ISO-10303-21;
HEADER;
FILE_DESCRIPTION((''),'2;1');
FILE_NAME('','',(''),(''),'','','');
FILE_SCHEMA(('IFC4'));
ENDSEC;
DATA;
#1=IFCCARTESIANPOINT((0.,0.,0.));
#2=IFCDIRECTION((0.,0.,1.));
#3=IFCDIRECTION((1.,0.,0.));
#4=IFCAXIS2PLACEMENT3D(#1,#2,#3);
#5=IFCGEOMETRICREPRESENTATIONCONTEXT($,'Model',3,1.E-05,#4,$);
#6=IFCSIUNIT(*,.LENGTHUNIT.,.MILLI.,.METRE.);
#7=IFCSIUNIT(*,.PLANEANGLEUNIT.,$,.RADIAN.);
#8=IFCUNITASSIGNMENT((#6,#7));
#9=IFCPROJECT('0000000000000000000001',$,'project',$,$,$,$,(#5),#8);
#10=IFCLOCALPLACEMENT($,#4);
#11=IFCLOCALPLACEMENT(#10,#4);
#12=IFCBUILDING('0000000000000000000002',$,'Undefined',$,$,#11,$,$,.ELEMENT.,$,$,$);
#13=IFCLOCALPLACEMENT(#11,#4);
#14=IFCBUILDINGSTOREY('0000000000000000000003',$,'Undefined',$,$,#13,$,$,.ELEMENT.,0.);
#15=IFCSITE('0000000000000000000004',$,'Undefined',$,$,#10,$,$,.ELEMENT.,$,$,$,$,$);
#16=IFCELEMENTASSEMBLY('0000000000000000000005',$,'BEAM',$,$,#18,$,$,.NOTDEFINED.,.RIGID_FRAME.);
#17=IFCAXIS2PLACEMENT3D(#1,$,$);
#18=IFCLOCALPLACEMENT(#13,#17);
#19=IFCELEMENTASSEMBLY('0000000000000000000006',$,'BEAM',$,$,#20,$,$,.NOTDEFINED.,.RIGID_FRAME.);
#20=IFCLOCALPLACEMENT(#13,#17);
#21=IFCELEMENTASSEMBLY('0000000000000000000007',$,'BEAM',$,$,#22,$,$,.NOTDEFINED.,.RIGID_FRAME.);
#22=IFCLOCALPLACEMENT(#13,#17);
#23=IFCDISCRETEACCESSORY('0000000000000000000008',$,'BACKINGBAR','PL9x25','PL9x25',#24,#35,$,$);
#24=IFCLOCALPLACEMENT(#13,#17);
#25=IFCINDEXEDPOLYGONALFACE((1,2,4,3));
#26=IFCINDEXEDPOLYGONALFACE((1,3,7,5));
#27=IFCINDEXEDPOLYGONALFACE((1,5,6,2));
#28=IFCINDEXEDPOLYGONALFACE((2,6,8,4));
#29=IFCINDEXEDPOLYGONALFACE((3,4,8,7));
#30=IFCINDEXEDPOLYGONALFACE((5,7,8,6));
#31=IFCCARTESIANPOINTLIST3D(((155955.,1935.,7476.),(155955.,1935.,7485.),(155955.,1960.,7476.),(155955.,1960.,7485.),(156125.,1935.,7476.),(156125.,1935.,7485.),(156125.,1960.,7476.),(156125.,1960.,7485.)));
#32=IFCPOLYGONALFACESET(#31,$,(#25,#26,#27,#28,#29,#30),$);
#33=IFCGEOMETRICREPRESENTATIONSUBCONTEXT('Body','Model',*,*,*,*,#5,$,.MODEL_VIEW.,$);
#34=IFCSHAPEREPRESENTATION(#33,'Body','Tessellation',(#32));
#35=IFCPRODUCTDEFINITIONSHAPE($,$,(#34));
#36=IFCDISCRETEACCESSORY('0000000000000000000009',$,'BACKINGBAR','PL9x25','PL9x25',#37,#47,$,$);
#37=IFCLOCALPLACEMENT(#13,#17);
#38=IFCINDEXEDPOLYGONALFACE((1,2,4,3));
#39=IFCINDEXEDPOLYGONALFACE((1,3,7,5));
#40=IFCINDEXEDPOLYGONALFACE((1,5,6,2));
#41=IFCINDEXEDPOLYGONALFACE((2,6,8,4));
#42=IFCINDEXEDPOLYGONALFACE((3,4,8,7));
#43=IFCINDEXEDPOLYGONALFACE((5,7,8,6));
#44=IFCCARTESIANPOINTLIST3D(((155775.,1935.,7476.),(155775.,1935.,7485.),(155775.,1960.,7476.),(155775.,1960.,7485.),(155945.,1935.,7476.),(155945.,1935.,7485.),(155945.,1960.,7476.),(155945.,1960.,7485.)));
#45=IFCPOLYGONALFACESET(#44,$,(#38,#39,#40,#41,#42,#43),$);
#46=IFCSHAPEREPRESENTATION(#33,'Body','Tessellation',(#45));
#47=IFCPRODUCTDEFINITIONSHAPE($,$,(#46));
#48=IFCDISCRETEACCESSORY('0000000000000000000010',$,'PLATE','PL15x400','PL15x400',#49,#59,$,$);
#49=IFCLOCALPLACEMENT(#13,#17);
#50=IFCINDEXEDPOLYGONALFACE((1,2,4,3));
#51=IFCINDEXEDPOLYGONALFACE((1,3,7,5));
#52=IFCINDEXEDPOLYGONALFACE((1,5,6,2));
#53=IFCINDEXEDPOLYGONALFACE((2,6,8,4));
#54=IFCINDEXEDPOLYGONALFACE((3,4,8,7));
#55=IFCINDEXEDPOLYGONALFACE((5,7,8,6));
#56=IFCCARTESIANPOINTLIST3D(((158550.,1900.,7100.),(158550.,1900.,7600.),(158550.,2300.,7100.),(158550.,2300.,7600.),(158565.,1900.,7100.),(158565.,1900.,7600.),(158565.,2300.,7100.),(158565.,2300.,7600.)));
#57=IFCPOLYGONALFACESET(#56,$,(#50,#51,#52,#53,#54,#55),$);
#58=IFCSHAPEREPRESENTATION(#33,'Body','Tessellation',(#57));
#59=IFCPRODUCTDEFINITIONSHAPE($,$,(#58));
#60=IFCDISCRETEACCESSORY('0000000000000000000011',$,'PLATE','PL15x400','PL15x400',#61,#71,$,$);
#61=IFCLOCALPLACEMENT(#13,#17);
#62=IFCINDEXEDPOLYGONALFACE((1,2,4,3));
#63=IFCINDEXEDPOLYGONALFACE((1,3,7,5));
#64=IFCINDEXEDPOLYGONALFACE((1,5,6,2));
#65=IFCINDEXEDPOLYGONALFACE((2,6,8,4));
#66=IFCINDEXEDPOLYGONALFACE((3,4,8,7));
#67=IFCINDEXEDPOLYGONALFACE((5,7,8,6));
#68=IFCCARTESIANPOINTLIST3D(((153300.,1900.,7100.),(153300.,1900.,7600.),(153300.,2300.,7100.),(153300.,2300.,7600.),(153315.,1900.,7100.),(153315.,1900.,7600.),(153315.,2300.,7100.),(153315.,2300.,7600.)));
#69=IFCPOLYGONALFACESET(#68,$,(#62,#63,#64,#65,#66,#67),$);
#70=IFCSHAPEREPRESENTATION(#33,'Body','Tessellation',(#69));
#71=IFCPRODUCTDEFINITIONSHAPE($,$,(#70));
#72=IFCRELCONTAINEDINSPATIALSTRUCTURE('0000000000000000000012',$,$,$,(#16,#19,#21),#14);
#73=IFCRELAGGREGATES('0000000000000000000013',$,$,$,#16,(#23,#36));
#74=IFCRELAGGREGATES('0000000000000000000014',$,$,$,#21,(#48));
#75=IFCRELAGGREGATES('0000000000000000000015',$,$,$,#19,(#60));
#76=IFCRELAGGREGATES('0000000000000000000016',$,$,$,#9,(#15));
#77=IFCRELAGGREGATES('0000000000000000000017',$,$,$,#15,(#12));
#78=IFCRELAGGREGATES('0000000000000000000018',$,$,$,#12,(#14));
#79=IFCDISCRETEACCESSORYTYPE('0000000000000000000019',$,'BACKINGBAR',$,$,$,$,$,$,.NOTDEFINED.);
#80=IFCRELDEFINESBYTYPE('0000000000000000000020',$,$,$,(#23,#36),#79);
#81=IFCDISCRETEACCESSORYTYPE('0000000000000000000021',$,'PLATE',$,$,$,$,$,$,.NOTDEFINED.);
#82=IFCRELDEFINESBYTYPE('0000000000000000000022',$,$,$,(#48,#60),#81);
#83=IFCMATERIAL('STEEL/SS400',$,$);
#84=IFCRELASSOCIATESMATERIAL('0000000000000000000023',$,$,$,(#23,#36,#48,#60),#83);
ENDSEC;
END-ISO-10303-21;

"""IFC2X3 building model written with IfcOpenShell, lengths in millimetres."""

from ifc_helpers import new_model, si_unit, frame, origin_with_axes, origin_2d_with_axis, place, context, subcontext, project, spatial, polyline, rectangle, outline, extrude, material, type_object, element, aggregate, save


model = new_model("IFC2X3")

# Units and contexts
model_context = context("Model", 3, precision=1e-05, world=origin_with_axes())
body_context = subcontext(model_context, "Body", "Model", "MODEL_VIEW")
ifc_project = project(units=[si_unit("LENGTHUNIT", "METRE", prefix="MILLI"), si_unit("PLANEANGLEUNIT", "RADIAN")], contexts=[model_context])

# Site, building, storey
site_placement = place(None, origin_with_axes())
site = spatial("IfcSite", under=ifc_project, at=site_placement, Name="Undefined", CompositionType="ELEMENT")
building_placement = place(site_placement, origin_with_axes())
building = spatial("IfcBuilding", under=site, at=building_placement, Name="Undefined", CompositionType="ELEMENT")
storey_placement = place(building_placement, origin_with_axes())
storey = spatial("IfcBuildingStorey", under=building, at=storey_placement, Name="Undefined", CompositionType="ELEMENT", Elevation=0.0)

# Shared definitions
ifc_material_1 = material(Name="STEEL/SS400")

# Element assemblies
assembly_1_placement = place(storey_placement, origin_with_axes())
assembly_1 = element("IfcElementAssembly", 1, at=assembly_1_placement, inside=storey, Name="BEAM", AssemblyPlace="NOTDEFINED", PredefinedType="RIGID_FRAME")
assembly_2_placement = place(storey_placement, origin_with_axes())
assembly_2 = element("IfcElementAssembly", 2, at=assembly_2_placement, inside=storey, Name="BEAM", AssemblyPlace="NOTDEFINED", PredefinedType="RIGID_FRAME")
assembly_3_placement = place(storey_placement, origin_with_axes())
assembly_3 = element("IfcElementAssembly", 3, at=assembly_3_placement, inside=storey, Name="BEAM", AssemblyPlace="NOTDEFINED", PredefinedType="RIGID_FRAME")

# Discrete accessories
discrete_accessory_type_1 = type_object("IfcDiscreteAccessoryType", Name="BACKINGBAR")
discrete_accessory_1_placement = place(assembly_1_placement, frame((156125.0, 1947.5, 7480.5), z_axis=(0.0, -1.0, 0.0), x_axis=(-1.0, 0.0, 0.0)))
discrete_accessory_1 = element("IfcDiscreteAccessory", 4, at=discrete_accessory_1_placement, type_object=discrete_accessory_type_1, material=ifc_material_1, Name="BACKINGBAR", Description="PL9x25", ObjectType="PL9x25", context=body_context, shape_type="SweptSolid", body=[
    extrude(rectangle(XDim=9.0, YDim=25.0, at=origin_2d_with_axis()), frame((170.0, 0.0, 0.0), z_axis=(-1.0, 0.0, 0.0), x_axis=(0.0, -1.0, 0.0)), (0.0, 0.0, 1.0), 170.0),
])
discrete_accessory_2_placement = place(assembly_1_placement, frame((155945.0, 1947.5, 7480.5), z_axis=(0.0, -1.0, 0.0), x_axis=(-1.0, 0.0, 0.0)))
discrete_accessory_2 = element("IfcDiscreteAccessory", 5, at=discrete_accessory_2_placement, type_object=discrete_accessory_type_1, material=ifc_material_1, Name="BACKINGBAR", Description="PL9x25", ObjectType="PL9x25", context=body_context, shape_type="SweptSolid", body=[
    extrude(rectangle(XDim=9.0, YDim=25.0, at=origin_2d_with_axis()), frame((170.0, 0.0, 0.0), z_axis=(-1.0, 0.0, 0.0), x_axis=(0.0, -1.0, 0.0)), (0.0, 0.0, 1.0), 170.0),
])
aggregate(assembly_1, [discrete_accessory_1, discrete_accessory_2])

# Discrete accessories
discrete_accessory_type_2 = type_object("IfcDiscreteAccessoryType", Name="PLATE")
discrete_accessory_3_placement = place(assembly_3_placement, frame((158557.5, 1900.0, 7600.0), z_axis=(1.0, 0.0, 0.0), x_axis=(0.0, 0.0, -1.0)))
discrete_accessory_3 = element("IfcDiscreteAccessory", 6, at=discrete_accessory_3_placement, type_object=discrete_accessory_type_2, material=ifc_material_1, Name="PLATE", Description="PL15x400", ObjectType="PL15x400", context=body_context, shape_type="SweptSolid", body=[
    extrude(outline(polyline([(0.0, 0.0), (500.0, 0.0), (500.0, 400.0), (0.0, 400.0), (0.0, 0.0)])), frame((0.0, 0.0, -7.5), z_axis=(0.0, 0.0, 1.0), x_axis=(1.0, 0.0, 0.0)), (0.0, 0.0, 1.0), 15.0),
])
discrete_accessory_4_placement = place(assembly_2_placement, frame((153307.5, 1900.0, 7600.0), z_axis=(1.0, 0.0, 0.0), x_axis=(0.0, 0.0, -1.0)))
discrete_accessory_4 = element("IfcDiscreteAccessory", 7, at=discrete_accessory_4_placement, type_object=discrete_accessory_type_2, material=ifc_material_1, Name="PLATE", Description="PL15x400", ObjectType="PL15x400", context=body_context, shape_type="SweptSolid", body=[
    extrude(outline(polyline([(0.0, 0.0), (500.0, 0.0), (500.0, 400.0), (0.0, 400.0), (0.0, 0.0)])), frame((0.0, 0.0, -7.5), z_axis=(0.0, 0.0, 1.0), x_axis=(1.0, 0.0, 0.0)), (0.0, 0.0, 1.0), 15.0),
])

aggregate(assembly_3, [discrete_accessory_3])
aggregate(assembly_2, [discrete_accessory_4])

save(model, "model.ifc")
